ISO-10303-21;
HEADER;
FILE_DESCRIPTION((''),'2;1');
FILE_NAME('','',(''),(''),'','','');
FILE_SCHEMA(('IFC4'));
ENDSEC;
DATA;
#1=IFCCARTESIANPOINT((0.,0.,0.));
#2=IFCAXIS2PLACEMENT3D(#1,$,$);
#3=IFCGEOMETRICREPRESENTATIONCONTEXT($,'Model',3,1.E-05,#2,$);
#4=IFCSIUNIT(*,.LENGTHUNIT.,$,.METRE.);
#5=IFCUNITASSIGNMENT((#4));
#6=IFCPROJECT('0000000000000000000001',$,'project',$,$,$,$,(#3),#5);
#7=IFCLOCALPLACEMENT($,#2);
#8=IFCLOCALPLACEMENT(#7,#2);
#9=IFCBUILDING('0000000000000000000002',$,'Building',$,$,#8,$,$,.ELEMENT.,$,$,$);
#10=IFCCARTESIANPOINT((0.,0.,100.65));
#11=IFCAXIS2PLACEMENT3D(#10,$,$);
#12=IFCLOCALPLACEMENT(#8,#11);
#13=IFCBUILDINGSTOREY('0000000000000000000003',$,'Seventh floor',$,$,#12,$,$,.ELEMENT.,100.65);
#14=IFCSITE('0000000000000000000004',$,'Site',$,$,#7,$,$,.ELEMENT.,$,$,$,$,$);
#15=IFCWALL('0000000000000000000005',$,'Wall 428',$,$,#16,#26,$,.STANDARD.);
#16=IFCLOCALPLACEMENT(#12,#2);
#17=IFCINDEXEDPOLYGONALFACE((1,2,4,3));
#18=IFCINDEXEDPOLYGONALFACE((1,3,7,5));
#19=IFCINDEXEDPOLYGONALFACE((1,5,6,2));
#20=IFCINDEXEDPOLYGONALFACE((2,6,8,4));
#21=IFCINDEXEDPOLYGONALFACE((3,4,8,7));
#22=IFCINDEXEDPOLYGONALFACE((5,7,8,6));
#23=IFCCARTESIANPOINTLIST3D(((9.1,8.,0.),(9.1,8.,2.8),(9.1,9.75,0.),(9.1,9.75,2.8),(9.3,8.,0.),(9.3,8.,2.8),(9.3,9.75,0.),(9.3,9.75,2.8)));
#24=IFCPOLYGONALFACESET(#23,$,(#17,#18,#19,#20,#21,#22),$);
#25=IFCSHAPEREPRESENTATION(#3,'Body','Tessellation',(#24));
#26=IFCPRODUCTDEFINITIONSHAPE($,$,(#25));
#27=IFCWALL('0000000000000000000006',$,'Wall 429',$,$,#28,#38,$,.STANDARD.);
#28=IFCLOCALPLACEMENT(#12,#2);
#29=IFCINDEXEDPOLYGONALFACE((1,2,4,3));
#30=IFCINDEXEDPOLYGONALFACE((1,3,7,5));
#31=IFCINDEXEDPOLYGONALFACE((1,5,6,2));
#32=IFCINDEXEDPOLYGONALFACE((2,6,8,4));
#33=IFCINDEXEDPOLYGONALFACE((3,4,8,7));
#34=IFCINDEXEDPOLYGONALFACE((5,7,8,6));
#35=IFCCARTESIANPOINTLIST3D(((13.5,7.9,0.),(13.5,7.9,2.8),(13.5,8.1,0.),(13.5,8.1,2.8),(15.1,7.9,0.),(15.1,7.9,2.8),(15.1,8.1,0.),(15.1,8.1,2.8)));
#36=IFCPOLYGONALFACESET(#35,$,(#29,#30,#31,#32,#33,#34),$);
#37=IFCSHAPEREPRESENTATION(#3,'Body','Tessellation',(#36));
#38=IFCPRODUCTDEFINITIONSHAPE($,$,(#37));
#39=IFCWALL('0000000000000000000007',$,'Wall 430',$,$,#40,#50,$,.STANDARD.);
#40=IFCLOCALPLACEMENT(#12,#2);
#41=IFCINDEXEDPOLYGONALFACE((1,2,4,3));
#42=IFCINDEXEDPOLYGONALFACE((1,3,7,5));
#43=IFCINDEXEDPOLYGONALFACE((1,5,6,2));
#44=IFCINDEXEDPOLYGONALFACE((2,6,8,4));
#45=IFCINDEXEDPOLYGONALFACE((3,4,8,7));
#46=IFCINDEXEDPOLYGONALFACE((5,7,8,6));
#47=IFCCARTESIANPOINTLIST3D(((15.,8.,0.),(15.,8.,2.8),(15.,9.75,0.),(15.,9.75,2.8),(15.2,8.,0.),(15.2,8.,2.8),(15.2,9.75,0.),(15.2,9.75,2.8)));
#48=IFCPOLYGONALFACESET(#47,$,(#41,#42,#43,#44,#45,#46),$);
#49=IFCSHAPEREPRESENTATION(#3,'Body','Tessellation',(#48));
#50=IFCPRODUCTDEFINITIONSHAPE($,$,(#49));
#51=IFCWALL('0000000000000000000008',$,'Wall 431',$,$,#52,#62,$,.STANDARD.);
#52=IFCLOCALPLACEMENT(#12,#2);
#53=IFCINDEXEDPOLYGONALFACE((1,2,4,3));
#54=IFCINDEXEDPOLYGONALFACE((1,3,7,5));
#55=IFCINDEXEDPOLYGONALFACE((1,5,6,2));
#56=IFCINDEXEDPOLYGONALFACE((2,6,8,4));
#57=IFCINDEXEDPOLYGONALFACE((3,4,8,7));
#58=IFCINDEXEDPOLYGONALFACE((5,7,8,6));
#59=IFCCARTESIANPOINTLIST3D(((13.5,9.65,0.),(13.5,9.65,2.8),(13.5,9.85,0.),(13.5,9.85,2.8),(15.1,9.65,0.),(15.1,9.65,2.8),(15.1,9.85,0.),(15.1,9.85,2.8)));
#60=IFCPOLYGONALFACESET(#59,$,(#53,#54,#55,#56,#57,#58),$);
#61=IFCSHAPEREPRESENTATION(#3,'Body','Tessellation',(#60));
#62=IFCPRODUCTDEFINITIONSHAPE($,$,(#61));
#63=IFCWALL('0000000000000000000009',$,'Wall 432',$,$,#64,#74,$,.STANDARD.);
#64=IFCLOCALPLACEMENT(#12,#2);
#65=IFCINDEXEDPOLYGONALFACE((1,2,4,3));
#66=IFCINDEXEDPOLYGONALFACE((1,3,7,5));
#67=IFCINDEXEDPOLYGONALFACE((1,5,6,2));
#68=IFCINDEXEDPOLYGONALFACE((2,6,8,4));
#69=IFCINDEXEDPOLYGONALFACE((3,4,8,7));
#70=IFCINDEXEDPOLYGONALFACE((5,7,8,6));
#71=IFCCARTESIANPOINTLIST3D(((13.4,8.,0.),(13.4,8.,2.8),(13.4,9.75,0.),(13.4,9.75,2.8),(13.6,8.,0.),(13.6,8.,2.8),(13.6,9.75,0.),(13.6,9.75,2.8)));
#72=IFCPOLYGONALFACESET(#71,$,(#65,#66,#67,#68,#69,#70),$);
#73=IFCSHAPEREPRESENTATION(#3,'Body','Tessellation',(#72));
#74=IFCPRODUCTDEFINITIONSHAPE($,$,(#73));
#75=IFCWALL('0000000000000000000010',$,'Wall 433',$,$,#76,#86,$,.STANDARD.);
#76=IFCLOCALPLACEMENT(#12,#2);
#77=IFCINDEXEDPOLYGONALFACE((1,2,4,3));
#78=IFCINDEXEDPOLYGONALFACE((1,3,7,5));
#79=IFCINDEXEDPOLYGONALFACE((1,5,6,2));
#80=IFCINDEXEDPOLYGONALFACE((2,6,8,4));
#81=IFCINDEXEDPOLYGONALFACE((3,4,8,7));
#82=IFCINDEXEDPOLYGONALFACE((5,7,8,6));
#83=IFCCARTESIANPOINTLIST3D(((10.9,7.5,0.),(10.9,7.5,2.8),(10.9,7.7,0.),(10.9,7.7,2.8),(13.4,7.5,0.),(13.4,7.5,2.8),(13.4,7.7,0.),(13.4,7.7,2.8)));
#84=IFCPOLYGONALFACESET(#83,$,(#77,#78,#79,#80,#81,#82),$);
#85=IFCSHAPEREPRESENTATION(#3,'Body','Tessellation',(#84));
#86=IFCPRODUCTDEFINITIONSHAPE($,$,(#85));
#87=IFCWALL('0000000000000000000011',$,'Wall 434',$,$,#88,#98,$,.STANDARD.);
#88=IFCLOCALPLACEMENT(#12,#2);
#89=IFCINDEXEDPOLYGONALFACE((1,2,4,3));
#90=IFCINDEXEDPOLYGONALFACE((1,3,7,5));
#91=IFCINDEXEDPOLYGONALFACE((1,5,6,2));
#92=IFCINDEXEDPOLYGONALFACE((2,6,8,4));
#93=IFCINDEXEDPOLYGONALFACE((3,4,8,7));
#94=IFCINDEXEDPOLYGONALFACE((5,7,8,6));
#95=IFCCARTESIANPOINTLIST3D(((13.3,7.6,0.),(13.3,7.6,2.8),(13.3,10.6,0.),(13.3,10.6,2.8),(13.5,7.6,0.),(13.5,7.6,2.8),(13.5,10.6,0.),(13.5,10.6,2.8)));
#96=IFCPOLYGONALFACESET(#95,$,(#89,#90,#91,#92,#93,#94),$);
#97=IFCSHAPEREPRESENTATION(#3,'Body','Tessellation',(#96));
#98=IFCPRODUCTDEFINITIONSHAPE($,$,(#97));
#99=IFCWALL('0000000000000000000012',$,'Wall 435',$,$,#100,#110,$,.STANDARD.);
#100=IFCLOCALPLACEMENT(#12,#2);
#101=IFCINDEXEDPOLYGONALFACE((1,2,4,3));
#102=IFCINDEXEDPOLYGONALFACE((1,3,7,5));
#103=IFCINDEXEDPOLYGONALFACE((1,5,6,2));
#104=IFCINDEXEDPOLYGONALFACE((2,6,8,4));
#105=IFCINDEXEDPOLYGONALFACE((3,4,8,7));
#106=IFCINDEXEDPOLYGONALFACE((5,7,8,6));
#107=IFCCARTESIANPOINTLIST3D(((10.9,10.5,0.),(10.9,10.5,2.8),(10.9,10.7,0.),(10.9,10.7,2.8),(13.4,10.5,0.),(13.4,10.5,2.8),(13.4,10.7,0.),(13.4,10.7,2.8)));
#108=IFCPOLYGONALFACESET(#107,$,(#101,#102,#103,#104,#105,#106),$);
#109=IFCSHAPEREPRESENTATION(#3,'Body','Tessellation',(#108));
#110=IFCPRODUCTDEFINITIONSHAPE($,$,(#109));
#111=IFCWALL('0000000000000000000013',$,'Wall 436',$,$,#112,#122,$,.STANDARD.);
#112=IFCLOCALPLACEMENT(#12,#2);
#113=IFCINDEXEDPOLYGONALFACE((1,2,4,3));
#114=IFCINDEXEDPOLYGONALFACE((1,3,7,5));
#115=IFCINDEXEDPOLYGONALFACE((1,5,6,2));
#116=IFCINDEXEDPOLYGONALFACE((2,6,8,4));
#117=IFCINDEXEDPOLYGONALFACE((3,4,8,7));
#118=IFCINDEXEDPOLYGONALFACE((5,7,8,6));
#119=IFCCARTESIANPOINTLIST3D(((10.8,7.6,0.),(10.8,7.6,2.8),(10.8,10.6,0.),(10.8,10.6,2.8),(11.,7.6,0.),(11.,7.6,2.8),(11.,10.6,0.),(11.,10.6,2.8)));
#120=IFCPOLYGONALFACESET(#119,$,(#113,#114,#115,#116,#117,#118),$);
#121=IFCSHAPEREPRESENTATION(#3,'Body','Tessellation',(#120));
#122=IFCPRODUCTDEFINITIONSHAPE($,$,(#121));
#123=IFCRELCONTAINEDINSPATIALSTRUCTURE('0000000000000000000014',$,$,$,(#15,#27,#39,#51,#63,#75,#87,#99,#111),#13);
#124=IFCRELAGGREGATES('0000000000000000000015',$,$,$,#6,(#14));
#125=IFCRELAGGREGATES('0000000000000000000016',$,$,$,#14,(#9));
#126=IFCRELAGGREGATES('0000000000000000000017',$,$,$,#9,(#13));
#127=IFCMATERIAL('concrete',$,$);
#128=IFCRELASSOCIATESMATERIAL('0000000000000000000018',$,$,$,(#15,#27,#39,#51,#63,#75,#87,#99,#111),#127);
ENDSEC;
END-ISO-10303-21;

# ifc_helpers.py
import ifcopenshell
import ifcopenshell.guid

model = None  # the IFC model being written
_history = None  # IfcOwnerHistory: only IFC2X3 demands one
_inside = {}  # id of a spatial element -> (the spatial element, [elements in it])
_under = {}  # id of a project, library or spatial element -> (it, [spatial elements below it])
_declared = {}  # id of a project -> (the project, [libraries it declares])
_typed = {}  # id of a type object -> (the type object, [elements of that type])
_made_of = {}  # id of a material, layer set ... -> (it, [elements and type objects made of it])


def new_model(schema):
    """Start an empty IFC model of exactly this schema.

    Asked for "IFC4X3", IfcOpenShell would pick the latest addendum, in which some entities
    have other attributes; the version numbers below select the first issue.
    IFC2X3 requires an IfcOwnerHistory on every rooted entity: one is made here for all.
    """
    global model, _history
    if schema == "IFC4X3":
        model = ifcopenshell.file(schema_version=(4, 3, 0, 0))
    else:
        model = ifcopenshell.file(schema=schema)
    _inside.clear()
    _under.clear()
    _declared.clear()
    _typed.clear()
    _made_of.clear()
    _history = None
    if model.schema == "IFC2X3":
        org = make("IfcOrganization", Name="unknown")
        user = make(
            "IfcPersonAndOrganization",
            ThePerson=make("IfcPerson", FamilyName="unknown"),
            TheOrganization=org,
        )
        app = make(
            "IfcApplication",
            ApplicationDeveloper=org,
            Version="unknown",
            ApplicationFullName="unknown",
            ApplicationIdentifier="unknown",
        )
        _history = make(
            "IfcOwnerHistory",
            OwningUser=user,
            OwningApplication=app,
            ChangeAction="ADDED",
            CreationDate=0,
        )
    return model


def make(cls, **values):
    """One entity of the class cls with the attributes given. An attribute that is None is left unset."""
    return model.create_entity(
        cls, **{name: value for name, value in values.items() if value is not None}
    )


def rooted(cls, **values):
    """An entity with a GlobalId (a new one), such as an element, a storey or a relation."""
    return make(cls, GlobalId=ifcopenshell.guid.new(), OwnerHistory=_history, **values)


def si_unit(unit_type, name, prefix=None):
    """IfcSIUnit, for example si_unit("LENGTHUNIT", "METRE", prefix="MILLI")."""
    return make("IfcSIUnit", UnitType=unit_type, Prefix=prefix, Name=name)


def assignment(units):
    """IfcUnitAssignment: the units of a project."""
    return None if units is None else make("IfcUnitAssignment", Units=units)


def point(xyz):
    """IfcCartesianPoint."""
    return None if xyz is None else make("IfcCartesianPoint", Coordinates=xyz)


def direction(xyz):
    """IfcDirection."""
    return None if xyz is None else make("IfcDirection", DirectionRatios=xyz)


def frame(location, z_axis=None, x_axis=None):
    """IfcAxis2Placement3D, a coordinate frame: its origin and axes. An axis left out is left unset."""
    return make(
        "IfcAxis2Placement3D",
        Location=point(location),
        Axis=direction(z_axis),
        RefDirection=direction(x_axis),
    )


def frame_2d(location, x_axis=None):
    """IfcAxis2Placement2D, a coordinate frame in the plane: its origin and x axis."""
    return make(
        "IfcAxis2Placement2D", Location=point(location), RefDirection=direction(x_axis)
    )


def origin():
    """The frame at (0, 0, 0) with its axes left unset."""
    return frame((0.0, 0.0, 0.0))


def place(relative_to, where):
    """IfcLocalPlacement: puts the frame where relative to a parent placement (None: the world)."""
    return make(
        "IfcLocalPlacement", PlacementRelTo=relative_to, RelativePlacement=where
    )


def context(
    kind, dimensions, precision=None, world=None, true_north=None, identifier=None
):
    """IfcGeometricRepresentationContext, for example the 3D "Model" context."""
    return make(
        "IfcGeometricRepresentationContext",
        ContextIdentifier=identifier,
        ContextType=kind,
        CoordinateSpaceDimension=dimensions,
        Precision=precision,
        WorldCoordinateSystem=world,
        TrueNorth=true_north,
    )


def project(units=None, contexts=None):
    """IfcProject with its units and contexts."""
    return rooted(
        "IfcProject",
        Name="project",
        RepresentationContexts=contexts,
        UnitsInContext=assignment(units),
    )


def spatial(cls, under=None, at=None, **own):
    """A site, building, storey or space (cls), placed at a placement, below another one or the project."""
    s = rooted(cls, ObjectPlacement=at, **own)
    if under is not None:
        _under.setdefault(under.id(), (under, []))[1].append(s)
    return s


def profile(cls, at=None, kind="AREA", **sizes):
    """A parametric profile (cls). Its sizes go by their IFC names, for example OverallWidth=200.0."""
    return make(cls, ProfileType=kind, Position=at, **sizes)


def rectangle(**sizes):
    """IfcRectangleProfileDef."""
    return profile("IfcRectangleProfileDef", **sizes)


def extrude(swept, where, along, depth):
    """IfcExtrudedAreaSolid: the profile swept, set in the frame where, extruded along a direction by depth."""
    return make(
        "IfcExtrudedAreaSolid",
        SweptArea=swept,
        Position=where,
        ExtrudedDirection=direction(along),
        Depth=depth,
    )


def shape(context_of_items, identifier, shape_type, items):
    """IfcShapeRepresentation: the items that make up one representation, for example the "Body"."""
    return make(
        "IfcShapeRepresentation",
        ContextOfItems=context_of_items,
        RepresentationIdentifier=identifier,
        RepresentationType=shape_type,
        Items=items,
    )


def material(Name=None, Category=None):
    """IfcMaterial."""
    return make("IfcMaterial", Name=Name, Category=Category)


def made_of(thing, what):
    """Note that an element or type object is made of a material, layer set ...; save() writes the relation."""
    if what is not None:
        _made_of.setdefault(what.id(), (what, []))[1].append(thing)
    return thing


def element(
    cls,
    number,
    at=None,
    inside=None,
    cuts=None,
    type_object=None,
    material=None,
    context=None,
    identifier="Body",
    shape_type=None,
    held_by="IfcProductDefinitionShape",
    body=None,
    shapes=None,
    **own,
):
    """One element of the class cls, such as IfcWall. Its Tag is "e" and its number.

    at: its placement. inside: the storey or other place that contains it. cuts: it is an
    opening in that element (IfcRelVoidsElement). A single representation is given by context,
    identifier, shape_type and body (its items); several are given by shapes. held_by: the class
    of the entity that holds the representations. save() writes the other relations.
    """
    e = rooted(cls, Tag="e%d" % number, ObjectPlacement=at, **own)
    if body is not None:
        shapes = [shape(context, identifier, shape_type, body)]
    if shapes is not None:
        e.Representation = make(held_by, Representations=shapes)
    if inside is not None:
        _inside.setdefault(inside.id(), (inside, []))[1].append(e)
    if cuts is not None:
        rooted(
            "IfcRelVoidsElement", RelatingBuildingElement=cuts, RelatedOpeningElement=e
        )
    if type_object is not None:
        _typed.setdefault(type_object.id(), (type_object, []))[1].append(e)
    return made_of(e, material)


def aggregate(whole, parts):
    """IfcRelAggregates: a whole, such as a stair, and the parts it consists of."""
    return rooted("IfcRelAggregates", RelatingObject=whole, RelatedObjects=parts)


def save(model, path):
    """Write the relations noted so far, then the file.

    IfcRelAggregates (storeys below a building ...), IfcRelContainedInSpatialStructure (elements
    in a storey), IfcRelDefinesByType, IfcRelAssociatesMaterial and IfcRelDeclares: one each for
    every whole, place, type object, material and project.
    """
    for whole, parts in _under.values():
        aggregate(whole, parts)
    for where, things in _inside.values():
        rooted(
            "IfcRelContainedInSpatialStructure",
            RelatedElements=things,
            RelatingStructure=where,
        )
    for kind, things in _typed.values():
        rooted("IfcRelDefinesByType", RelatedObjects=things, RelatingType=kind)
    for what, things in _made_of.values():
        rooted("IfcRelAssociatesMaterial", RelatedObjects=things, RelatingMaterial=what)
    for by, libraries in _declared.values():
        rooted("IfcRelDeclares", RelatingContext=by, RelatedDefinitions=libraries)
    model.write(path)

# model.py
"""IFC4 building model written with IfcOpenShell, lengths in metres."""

from ifc_helpers import new_model, si_unit, frame, frame_2d, origin, place, context, project, spatial, rectangle, extrude, material, element, save


model = new_model("IFC4")

# Units and contexts
model_context = context("Model", 3, precision=1e-05, world=origin())
ifc_project = project(units=[si_unit("LENGTHUNIT", "METRE")], contexts=[model_context])

# Site, building, storey
site_placement = place(None, origin())
site = spatial("IfcSite", under=ifc_project, at=site_placement, Name="Site", CompositionType="ELEMENT")
building_placement = place(site_placement, origin())
building = spatial("IfcBuilding", under=site, at=building_placement, Name="Building", CompositionType="ELEMENT")
storey_placement = place(building_placement, frame((0.0, 0.0, 100.65)))
storey = spatial("IfcBuildingStorey", under=building, at=storey_placement, Name="Seventh floor", CompositionType="ELEMENT", Elevation=100.65)

# Shared definitions
ifc_material = material(Name="concrete")

# Walls
wall_1_placement = place(storey_placement, frame((9.2, 9.75, 0.0), z_axis=(0.0, 0.0, 1.0), x_axis=(0.0, -1.0, 0.0)))
element("IfcWall", 1, at=wall_1_placement, inside=storey, material=ifc_material, Name="Wall 428", PredefinedType="STANDARD", context=model_context, shape_type="SweptSolid", body=[
    extrude(rectangle(XDim=1.75, YDim=0.2, at=frame_2d((0.875, 0.0))), origin(), (0.0, 0.0, 1.0), 2.8),
])
wall_2_placement = place(storey_placement, frame((13.5, 8.0, 0.0), z_axis=(0.0, 0.0, 1.0), x_axis=(1.0, 0.0, 0.0)))
element("IfcWall", 2, at=wall_2_placement, inside=storey, material=ifc_material, Name="Wall 429", PredefinedType="STANDARD", context=model_context, shape_type="SweptSolid", body=[
    extrude(rectangle(XDim=1.6, YDim=0.2, at=frame_2d((0.8, 0.0))), origin(), (0.0, 0.0, 1.0), 2.8),
])
wall_3_placement = place(storey_placement, frame((15.1, 8.0, 0.0), z_axis=(0.0, 0.0, 1.0), x_axis=(0.0, 1.0, 0.0)))
element("IfcWall", 3, at=wall_3_placement, inside=storey, material=ifc_material, Name="Wall 430", PredefinedType="STANDARD", context=model_context, shape_type="SweptSolid", body=[
    extrude(rectangle(XDim=1.75, YDim=0.2, at=frame_2d((0.875, 0.0))), origin(), (0.0, 0.0, 1.0), 2.8),
])
wall_4_placement = place(storey_placement, frame((15.1, 9.75, 0.0), z_axis=(0.0, 0.0, 1.0), x_axis=(-1.0, 0.0, 0.0)))
element("IfcWall", 4, at=wall_4_placement, inside=storey, material=ifc_material, Name="Wall 431", PredefinedType="STANDARD", context=model_context, shape_type="SweptSolid", body=[
    extrude(rectangle(XDim=1.6, YDim=0.2, at=frame_2d((0.8, 0.0))), origin(), (0.0, 0.0, 1.0), 2.8),
])
wall_5_placement = place(storey_placement, frame((13.5, 9.75, 0.0), z_axis=(0.0, 0.0, 1.0), x_axis=(0.0, -1.0, 0.0)))
element("IfcWall", 5, at=wall_5_placement, inside=storey, material=ifc_material, Name="Wall 432", PredefinedType="STANDARD", context=model_context, shape_type="SweptSolid", body=[
    extrude(rectangle(XDim=1.75, YDim=0.2, at=frame_2d((0.875, 0.0))), origin(), (0.0, 0.0, 1.0), 2.8),
])
wall_6_placement = place(storey_placement, frame((10.9, 7.6, 0.0), z_axis=(0.0, 0.0, 1.0), x_axis=(1.0, 0.0, 0.0)))
element("IfcWall", 6, at=wall_6_placement, inside=storey, material=ifc_material, Name="Wall 433", PredefinedType="STANDARD", context=model_context, shape_type="SweptSolid", body=[
    extrude(rectangle(XDim=2.5, YDim=0.2, at=frame_2d((1.25, 0.0))), origin(), (0.0, 0.0, 1.0), 2.8),
])
wall_7_placement = place(storey_placement, frame((13.4, 7.6, 0.0), z_axis=(0.0, 0.0, 1.0), x_axis=(0.0, 1.0, 0.0)))
element("IfcWall", 7, at=wall_7_placement, inside=storey, material=ifc_material, Name="Wall 434", PredefinedType="STANDARD", context=model_context, shape_type="SweptSolid", body=[
    extrude(rectangle(XDim=3.0, YDim=0.2, at=frame_2d((1.5, 0.0))), origin(), (0.0, 0.0, 1.0), 2.8),
])
wall_8_placement = place(storey_placement, frame((13.4, 10.6, 0.0), z_axis=(0.0, 0.0, 1.0), x_axis=(-1.0, 0.0, 0.0)))
element("IfcWall", 8, at=wall_8_placement, inside=storey, material=ifc_material, Name="Wall 435", PredefinedType="STANDARD", context=model_context, shape_type="SweptSolid", body=[
    extrude(rectangle(XDim=2.5, YDim=0.2, at=frame_2d((1.25, 0.0))), origin(), (0.0, 0.0, 1.0), 2.8),
])
wall_9_placement = place(storey_placement, frame((10.9, 10.6, 0.0), z_axis=(0.0, 0.0, 1.0), x_axis=(0.0, -1.0, 0.0)))
element("IfcWall", 9, at=wall_9_placement, inside=storey, material=ifc_material, Name="Wall 436", PredefinedType="STANDARD", context=model_context, shape_type="SweptSolid", body=[
    extrude(rectangle(XDim=3.0, YDim=0.2, at=frame_2d((1.5, 0.0))), origin(), (0.0, 0.0, 1.0), 2.8),
])

save(model, "model.ifc")
